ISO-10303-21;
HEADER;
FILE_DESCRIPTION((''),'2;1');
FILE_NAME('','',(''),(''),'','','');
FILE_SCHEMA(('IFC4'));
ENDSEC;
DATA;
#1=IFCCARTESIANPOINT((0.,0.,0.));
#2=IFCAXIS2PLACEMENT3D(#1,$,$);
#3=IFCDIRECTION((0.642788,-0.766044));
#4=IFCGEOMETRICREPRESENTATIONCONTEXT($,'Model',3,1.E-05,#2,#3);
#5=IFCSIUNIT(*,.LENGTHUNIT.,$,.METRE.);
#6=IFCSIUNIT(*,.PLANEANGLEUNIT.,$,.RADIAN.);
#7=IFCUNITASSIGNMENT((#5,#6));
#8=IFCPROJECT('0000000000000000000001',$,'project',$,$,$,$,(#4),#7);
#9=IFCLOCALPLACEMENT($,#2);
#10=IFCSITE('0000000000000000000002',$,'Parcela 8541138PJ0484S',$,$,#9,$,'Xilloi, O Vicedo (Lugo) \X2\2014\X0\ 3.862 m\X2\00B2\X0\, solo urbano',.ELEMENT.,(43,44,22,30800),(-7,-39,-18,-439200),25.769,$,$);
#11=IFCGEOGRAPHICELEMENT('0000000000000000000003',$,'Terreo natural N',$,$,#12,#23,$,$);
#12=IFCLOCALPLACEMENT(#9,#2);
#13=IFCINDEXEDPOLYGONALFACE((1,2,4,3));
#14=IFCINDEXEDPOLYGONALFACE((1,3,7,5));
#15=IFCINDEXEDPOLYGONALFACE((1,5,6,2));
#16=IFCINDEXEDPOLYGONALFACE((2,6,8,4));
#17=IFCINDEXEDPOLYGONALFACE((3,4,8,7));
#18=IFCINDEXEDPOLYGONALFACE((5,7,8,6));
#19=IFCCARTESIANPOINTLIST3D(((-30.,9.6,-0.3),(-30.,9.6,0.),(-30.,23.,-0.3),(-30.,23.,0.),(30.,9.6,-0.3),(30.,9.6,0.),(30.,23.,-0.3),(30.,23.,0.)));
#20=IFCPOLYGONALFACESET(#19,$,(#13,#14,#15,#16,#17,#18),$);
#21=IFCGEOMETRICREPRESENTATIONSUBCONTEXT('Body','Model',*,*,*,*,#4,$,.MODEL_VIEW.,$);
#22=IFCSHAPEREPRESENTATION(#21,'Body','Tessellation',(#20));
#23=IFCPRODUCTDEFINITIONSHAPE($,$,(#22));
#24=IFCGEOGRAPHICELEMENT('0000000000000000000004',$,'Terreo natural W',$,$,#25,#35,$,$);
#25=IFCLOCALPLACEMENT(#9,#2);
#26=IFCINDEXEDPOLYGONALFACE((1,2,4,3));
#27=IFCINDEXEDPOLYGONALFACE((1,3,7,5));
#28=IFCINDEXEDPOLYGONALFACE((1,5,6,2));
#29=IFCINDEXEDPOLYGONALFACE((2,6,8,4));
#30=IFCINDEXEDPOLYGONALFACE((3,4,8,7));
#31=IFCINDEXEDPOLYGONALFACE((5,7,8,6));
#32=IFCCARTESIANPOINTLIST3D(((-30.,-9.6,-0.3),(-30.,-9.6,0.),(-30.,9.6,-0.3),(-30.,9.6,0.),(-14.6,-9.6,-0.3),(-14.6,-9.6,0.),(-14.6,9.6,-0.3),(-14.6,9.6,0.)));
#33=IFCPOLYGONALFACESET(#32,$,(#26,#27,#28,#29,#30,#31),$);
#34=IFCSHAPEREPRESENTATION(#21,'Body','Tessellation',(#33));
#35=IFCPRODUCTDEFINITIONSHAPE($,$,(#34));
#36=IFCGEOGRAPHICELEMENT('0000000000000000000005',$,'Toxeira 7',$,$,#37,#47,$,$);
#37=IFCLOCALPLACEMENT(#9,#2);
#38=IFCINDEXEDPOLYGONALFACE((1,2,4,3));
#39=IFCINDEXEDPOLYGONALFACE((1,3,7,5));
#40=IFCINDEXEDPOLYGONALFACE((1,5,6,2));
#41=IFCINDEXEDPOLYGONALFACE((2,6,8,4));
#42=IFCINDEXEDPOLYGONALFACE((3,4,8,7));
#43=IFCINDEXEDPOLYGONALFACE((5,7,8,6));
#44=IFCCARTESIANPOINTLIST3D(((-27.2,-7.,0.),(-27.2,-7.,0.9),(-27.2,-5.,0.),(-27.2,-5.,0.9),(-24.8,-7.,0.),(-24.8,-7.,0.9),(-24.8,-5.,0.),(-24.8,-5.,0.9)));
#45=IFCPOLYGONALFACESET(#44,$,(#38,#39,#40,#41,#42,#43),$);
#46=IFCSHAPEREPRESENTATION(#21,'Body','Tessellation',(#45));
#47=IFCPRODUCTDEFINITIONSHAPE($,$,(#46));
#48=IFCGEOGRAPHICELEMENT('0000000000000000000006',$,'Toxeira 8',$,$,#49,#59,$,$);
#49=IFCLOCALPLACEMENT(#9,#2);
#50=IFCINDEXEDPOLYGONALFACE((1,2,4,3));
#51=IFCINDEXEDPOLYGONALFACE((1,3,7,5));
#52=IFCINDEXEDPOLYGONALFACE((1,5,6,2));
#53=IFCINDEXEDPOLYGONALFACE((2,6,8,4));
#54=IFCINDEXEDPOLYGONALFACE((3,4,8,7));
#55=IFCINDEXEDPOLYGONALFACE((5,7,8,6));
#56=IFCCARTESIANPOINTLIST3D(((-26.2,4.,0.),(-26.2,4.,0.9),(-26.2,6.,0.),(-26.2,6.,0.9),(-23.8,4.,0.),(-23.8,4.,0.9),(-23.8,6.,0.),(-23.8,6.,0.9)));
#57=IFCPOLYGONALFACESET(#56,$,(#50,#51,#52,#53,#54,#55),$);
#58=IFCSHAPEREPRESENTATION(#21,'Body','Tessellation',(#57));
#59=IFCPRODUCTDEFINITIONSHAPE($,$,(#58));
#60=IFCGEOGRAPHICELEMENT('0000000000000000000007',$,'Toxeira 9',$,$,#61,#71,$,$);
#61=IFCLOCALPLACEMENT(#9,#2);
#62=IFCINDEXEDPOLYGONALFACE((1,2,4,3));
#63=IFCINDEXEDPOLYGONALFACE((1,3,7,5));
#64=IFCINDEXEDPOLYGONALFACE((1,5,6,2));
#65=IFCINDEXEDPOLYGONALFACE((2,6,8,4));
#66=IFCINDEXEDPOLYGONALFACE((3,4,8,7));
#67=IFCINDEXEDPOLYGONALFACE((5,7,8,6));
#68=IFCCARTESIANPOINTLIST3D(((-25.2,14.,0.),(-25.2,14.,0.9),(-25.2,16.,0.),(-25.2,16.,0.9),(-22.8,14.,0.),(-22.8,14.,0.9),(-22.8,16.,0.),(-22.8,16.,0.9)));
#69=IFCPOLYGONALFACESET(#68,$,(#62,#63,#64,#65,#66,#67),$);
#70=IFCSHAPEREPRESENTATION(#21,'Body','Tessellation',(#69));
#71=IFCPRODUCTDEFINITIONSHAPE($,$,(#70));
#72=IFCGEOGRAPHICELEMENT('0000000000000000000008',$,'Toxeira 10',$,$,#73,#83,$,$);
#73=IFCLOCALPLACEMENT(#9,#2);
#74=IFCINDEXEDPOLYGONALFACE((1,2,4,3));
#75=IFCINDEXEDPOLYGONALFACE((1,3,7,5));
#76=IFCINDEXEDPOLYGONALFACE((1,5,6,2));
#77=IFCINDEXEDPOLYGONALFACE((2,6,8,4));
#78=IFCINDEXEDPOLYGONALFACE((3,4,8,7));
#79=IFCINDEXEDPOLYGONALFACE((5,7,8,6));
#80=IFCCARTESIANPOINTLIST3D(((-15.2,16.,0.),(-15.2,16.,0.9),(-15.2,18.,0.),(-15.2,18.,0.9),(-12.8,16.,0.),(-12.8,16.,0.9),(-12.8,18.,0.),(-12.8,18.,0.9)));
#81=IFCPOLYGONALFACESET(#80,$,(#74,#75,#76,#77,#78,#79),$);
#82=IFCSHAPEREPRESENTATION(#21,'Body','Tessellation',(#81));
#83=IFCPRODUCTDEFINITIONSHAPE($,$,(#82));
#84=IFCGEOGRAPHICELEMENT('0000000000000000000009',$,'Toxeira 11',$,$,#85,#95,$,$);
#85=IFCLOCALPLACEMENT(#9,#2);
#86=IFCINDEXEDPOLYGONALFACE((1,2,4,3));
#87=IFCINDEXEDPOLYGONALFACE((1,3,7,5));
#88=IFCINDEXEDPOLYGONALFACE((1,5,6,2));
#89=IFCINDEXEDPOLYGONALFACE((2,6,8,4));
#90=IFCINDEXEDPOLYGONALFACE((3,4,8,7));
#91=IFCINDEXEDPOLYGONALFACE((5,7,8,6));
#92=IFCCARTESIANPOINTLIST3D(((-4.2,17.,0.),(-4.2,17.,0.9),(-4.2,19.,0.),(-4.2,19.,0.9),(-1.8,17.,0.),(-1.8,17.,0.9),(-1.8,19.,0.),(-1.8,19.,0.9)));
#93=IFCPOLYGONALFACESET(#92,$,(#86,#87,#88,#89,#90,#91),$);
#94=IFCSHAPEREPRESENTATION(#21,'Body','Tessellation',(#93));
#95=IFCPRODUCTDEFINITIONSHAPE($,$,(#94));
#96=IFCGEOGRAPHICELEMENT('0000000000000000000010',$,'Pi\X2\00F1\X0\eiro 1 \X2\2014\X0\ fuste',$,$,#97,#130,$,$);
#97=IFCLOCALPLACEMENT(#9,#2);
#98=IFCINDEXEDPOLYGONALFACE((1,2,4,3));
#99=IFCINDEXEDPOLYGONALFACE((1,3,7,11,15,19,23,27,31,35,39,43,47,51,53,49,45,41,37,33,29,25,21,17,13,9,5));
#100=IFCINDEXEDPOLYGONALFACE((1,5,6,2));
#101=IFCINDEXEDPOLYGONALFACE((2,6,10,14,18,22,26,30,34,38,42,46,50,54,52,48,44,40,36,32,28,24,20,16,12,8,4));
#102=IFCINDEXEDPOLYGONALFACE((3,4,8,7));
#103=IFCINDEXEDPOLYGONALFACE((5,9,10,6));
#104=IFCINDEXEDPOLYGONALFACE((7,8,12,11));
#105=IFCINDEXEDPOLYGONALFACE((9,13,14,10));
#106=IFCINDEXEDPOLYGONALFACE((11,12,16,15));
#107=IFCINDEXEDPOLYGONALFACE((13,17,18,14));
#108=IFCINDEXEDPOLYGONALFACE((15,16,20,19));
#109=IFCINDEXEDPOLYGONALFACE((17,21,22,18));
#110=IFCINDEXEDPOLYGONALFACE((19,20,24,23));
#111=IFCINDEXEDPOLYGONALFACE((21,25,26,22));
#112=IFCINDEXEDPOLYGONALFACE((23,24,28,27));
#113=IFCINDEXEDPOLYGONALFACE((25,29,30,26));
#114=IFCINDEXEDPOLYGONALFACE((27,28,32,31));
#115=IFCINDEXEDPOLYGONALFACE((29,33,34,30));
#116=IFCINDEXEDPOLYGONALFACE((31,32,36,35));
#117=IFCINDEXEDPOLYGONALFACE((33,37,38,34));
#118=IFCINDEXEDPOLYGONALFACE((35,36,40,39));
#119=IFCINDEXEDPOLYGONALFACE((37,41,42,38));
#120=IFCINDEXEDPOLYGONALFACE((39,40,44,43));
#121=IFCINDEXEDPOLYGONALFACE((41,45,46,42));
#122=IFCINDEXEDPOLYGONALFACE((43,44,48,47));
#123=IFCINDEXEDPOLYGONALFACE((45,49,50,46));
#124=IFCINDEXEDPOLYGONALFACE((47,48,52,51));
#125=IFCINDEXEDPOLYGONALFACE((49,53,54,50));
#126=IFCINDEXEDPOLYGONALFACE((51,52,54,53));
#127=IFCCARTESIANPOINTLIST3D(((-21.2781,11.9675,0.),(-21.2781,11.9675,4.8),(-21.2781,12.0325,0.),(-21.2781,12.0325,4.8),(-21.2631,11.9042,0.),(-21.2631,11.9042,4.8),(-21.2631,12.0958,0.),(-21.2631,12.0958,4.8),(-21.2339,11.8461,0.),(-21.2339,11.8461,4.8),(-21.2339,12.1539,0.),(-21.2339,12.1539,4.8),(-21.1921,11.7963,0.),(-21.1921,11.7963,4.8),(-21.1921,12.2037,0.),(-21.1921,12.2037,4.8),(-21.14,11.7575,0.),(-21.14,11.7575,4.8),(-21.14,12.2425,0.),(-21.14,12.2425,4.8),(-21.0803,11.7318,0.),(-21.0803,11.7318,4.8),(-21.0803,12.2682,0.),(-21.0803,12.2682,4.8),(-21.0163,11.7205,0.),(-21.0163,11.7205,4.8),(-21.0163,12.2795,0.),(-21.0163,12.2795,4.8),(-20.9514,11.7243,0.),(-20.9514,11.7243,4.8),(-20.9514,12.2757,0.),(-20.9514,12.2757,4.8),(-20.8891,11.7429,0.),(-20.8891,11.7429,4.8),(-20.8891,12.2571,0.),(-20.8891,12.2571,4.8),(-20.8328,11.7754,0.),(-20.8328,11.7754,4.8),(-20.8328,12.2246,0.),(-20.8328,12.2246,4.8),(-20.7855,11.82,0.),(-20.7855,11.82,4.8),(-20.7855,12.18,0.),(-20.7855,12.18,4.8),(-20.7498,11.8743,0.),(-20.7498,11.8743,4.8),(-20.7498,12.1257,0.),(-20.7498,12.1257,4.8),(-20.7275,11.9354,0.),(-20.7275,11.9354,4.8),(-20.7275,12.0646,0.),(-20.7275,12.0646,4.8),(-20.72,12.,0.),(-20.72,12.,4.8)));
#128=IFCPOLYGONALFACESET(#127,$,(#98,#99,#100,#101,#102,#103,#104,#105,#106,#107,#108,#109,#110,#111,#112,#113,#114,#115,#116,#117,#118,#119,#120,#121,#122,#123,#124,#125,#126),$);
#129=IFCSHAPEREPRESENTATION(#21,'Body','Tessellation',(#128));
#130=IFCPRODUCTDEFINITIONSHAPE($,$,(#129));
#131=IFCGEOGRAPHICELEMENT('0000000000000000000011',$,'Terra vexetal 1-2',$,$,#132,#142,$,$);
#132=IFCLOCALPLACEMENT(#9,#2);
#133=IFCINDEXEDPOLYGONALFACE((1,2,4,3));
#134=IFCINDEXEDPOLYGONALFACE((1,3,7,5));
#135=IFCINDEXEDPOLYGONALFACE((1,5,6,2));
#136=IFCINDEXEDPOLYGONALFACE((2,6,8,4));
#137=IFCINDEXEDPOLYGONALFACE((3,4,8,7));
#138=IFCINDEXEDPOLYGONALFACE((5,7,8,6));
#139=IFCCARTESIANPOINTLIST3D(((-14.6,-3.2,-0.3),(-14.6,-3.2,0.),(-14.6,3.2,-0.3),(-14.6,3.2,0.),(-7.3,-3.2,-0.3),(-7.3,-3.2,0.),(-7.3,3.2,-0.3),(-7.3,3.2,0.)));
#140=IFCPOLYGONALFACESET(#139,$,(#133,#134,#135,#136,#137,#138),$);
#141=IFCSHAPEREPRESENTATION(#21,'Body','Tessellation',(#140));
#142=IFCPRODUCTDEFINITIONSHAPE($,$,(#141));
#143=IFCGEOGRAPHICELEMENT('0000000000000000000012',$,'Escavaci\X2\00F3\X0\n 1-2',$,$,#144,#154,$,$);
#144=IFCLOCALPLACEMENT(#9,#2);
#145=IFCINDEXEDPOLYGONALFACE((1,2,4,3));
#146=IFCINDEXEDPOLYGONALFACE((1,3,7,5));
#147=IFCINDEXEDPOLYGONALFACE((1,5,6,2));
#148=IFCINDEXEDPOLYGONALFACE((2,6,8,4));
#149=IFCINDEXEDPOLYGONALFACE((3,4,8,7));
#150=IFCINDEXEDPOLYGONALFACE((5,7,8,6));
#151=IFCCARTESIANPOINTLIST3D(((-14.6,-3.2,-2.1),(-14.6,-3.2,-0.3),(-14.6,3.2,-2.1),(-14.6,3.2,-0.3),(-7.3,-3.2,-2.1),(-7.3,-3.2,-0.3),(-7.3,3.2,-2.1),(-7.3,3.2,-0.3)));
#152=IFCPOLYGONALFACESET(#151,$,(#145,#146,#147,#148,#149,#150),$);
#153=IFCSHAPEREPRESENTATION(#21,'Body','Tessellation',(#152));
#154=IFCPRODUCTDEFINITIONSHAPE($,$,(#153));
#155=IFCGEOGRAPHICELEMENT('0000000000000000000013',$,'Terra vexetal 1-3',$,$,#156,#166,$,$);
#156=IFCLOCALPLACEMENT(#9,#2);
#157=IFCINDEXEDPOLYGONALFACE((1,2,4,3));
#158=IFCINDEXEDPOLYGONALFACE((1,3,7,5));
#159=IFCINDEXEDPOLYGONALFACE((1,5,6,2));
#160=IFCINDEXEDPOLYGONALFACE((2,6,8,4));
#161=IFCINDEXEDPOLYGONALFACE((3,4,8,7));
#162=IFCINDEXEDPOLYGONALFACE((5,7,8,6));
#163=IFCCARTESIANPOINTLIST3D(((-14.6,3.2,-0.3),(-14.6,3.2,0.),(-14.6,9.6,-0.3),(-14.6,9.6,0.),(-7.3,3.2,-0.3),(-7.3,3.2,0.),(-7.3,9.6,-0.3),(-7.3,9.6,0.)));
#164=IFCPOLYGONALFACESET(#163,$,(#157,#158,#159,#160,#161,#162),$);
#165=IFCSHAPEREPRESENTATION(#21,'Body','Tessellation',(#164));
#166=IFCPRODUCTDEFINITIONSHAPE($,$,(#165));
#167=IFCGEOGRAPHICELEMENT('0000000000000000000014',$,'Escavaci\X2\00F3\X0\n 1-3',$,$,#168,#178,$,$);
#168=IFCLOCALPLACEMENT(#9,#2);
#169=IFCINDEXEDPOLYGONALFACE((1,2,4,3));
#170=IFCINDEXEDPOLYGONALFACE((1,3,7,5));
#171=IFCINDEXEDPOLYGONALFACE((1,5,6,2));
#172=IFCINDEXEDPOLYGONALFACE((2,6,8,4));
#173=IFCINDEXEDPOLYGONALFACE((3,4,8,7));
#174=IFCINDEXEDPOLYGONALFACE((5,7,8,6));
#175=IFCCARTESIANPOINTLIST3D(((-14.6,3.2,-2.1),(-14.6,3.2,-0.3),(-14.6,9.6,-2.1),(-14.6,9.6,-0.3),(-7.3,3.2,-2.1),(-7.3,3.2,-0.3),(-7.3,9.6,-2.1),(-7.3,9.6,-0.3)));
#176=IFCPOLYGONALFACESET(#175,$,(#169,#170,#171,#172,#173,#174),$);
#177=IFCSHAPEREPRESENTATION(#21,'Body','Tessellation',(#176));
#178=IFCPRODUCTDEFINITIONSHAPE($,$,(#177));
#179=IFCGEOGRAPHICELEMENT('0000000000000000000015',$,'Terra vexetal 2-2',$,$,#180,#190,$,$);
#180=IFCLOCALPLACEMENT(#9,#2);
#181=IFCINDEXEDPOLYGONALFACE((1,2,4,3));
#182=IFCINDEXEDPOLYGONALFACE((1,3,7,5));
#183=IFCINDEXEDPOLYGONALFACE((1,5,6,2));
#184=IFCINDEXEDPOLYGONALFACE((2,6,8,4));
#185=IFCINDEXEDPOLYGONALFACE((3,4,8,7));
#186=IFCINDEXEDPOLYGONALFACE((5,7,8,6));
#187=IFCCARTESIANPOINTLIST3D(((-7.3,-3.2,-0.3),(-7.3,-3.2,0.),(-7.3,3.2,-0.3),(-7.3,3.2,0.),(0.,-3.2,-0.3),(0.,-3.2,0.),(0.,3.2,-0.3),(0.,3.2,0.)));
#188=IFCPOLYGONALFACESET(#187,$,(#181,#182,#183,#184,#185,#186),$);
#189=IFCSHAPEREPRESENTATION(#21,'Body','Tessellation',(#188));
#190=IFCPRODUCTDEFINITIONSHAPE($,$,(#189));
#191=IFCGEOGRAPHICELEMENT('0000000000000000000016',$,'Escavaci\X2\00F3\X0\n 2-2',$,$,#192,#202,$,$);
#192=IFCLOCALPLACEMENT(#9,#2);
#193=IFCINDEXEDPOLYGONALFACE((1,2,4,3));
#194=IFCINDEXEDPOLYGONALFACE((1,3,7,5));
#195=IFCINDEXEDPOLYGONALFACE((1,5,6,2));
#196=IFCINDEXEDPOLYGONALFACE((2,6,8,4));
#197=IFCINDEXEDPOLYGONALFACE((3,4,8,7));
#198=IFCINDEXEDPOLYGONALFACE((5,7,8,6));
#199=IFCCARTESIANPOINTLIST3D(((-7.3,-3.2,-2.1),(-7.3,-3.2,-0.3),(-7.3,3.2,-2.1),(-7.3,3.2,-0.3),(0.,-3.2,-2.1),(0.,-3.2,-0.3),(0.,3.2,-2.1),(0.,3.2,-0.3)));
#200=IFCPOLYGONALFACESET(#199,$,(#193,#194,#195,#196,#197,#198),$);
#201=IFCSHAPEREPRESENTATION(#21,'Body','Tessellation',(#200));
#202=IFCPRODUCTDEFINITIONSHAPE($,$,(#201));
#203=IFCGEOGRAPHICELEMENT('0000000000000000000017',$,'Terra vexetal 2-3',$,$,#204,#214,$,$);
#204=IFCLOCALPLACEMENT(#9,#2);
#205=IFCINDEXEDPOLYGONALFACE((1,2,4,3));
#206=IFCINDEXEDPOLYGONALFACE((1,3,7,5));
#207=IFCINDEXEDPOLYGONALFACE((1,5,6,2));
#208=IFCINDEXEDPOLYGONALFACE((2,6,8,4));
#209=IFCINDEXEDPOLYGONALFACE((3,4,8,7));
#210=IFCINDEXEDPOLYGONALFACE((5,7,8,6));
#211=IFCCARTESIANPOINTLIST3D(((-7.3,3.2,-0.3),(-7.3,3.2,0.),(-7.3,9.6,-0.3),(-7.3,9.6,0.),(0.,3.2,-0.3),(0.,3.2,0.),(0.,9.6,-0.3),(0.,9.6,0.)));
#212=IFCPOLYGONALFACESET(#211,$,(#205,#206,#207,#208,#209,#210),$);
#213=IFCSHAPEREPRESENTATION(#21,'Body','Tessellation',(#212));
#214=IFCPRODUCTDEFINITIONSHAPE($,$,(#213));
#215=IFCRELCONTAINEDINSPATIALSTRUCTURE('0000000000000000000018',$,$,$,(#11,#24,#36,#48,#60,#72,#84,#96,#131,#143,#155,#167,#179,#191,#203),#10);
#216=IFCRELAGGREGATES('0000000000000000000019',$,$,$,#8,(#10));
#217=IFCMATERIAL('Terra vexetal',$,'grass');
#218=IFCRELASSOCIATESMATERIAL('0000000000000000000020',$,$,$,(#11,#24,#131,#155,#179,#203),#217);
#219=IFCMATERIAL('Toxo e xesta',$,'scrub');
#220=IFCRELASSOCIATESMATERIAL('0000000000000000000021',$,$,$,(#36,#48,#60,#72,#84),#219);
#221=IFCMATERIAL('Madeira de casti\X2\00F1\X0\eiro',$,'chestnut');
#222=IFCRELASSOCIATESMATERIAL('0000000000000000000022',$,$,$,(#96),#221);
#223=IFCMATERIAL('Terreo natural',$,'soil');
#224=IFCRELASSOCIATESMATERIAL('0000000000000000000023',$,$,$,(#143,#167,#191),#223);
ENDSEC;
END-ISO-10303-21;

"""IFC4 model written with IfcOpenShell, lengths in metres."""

from ifc_helpers import new_model, si_unit, direction, frame, origin, origin_2d, place, context, subcontext, project, spatial, rectangle, circle, extrude, material, element, save


model = new_model("IFC4")

# Units and contexts
model_context = context("Model", 3, precision=1e-05, world=origin(), true_north=direction((0.642788, -0.766044)))
body_context = subcontext(model_context, "Body", "Model", "MODEL_VIEW")
ifc_project = project(units=[si_unit("LENGTHUNIT", "METRE"), si_unit("PLANEANGLEUNIT", "RADIAN")], contexts=[model_context])

# Site
site_placement = place(None, origin())
site = spatial("IfcSite", under=ifc_project, at=site_placement, Name="Parcela 8541138PJ0484S", LongName="Xilloi, O Vicedo (Lugo) — 3.862 m², solo urbano", CompositionType="ELEMENT", RefLatitude=(43, 44, 22, 30800), RefLongitude=(-7, -39, -18, -439200), RefElevation=25.769)

# Geographic elements
ifc_material_1 = material(Name="Terra vexetal", Category="grass")
geographic_element_1_placement = place(site_placement, frame((0.0, 16.3, -0.15)))
element("IfcGeographicElement", 1, at=geographic_element_1_placement, inside=site, material=ifc_material_1, Name="Terreo natural N", context=body_context, shape_type="SweptSolid", body=[
    extrude(rectangle(XDim=60.0, YDim=13.4, at=origin_2d()), frame((0.0, 0.0, -0.15)), (0.0, 0.0, 1.0), 0.3),
])
geographic_element_2_placement = place(site_placement, frame((-22.3, 0.0, -0.15)))
element("IfcGeographicElement", 2, at=geographic_element_2_placement, inside=site, material=ifc_material_1, Name="Terreo natural W", context=body_context, shape_type="SweptSolid", body=[
    extrude(rectangle(XDim=15.4, YDim=19.2, at=origin_2d()), frame((0.0, 0.0, -0.15)), (0.0, 0.0, 1.0), 0.3),
])
ifc_material_2 = material(Name="Toxo e xesta", Category="scrub")
for number, where, name in (
    (3, (-26.0, -6.0, 0.45), "Toxeira 7"),
    (4, (-25.0, 5.0, 0.45), "Toxeira 8"),
    (5, (-24.0, 15.0, 0.45), "Toxeira 9"),
    (6, (-14.0, 17.0, 0.45), "Toxeira 10"),
    (7, (-3.0, 18.0, 0.45), "Toxeira 11"),
):
    element("IfcGeographicElement", number, at=place(site_placement, frame(where)), inside=site, material=ifc_material_2, Name=name, context=body_context, shape_type="SweptSolid", body=[
        extrude(rectangle(XDim=2.4, YDim=2.0, at=origin_2d()), frame((0.0, 0.0, -0.45)), (0.0, 0.0, 1.0), 0.9),
    ])
ifc_material_3 = material(Name="Madeira de castiñeiro", Category="chestnut")
geographic_element_3_placement = place(site_placement, frame((-21.0, 12.0, 2.4)))
element("IfcGeographicElement", 8, at=geographic_element_3_placement, inside=site, material=ifc_material_3, Name="Piñeiro 1 — fuste", context=body_context, shape_type="SweptSolid", body=[
    extrude(circle(Radius=0.28, at=origin_2d()), frame((0.0, 0.0, -2.4)), (0.0, 0.0, 1.0), 4.8),
])
geographic_element_4_placement = place(site_placement, frame((-10.95, 0.0, -0.15)))
element("IfcGeographicElement", 9, at=geographic_element_4_placement, inside=site, material=ifc_material_1, Name="Terra vexetal 1-2", context=body_context, shape_type="SweptSolid", body=[
    extrude(rectangle(XDim=7.3, YDim=6.4, at=origin_2d()), frame((0.0, 0.0, -0.15)), (0.0, 0.0, 1.0), 0.3),
])
ifc_material_4 = material(Name="Terreo natural", Category="soil")
geographic_element_5_placement = place(site_placement, frame((-10.95, 0.0, -1.2)))
element("IfcGeographicElement", 10, at=geographic_element_5_placement, inside=site, material=ifc_material_4, Name="Escavación 1-2", context=body_context, shape_type="SweptSolid", body=[
    extrude(rectangle(XDim=7.3, YDim=6.4, at=origin_2d()), frame((0.0, 0.0, -0.9)), (0.0, 0.0, 1.0), 1.8),
])
geographic_element_6_placement = place(site_placement, frame((-10.95, 6.4, -0.15)))
element("IfcGeographicElement", 11, at=geographic_element_6_placement, inside=site, material=ifc_material_1, Name="Terra vexetal 1-3", context=body_context, shape_type="SweptSolid", body=[
    extrude(rectangle(XDim=7.3, YDim=6.4, at=origin_2d()), frame((0.0, 0.0, -0.15)), (0.0, 0.0, 1.0), 0.3),
])
geographic_element_7_placement = place(site_placement, frame((-10.95, 6.4, -1.2)))
element("IfcGeographicElement", 12, at=geographic_element_7_placement, inside=site, material=ifc_material_4, Name="Escavación 1-3", context=body_context, shape_type="SweptSolid", body=[
    extrude(rectangle(XDim=7.3, YDim=6.4, at=origin_2d()), frame((0.0, 0.0, -0.9)), (0.0, 0.0, 1.0), 1.8),
])
geographic_element_8_placement = place(site_placement, frame((-3.65, 0.0, -0.15)))
element("IfcGeographicElement", 13, at=geographic_element_8_placement, inside=site, material=ifc_material_1, Name="Terra vexetal 2-2", context=body_context, shape_type="SweptSolid", body=[
    extrude(rectangle(XDim=7.3, YDim=6.4, at=origin_2d()), frame((0.0, 0.0, -0.15)), (0.0, 0.0, 1.0), 0.3),
])
geographic_element_9_placement = place(site_placement, frame((-3.65, 0.0, -1.2)))
element("IfcGeographicElement", 14, at=geographic_element_9_placement, inside=site, material=ifc_material_4, Name="Escavación 2-2", context=body_context, shape_type="SweptSolid", body=[
    extrude(rectangle(XDim=7.3, YDim=6.4, at=origin_2d()), frame((0.0, 0.0, -0.9)), (0.0, 0.0, 1.0), 1.8),
])
geographic_element_10_placement = place(site_placement, frame((-3.65, 6.4, -0.15)))
element("IfcGeographicElement", 15, at=geographic_element_10_placement, inside=site, material=ifc_material_1, Name="Terra vexetal 2-3", context=body_context, shape_type="SweptSolid", body=[
    extrude(rectangle(XDim=7.3, YDim=6.4, at=origin_2d()), frame((0.0, 0.0, -0.15)), (0.0, 0.0, 1.0), 0.3),
])

save(model, "model.ifc")
